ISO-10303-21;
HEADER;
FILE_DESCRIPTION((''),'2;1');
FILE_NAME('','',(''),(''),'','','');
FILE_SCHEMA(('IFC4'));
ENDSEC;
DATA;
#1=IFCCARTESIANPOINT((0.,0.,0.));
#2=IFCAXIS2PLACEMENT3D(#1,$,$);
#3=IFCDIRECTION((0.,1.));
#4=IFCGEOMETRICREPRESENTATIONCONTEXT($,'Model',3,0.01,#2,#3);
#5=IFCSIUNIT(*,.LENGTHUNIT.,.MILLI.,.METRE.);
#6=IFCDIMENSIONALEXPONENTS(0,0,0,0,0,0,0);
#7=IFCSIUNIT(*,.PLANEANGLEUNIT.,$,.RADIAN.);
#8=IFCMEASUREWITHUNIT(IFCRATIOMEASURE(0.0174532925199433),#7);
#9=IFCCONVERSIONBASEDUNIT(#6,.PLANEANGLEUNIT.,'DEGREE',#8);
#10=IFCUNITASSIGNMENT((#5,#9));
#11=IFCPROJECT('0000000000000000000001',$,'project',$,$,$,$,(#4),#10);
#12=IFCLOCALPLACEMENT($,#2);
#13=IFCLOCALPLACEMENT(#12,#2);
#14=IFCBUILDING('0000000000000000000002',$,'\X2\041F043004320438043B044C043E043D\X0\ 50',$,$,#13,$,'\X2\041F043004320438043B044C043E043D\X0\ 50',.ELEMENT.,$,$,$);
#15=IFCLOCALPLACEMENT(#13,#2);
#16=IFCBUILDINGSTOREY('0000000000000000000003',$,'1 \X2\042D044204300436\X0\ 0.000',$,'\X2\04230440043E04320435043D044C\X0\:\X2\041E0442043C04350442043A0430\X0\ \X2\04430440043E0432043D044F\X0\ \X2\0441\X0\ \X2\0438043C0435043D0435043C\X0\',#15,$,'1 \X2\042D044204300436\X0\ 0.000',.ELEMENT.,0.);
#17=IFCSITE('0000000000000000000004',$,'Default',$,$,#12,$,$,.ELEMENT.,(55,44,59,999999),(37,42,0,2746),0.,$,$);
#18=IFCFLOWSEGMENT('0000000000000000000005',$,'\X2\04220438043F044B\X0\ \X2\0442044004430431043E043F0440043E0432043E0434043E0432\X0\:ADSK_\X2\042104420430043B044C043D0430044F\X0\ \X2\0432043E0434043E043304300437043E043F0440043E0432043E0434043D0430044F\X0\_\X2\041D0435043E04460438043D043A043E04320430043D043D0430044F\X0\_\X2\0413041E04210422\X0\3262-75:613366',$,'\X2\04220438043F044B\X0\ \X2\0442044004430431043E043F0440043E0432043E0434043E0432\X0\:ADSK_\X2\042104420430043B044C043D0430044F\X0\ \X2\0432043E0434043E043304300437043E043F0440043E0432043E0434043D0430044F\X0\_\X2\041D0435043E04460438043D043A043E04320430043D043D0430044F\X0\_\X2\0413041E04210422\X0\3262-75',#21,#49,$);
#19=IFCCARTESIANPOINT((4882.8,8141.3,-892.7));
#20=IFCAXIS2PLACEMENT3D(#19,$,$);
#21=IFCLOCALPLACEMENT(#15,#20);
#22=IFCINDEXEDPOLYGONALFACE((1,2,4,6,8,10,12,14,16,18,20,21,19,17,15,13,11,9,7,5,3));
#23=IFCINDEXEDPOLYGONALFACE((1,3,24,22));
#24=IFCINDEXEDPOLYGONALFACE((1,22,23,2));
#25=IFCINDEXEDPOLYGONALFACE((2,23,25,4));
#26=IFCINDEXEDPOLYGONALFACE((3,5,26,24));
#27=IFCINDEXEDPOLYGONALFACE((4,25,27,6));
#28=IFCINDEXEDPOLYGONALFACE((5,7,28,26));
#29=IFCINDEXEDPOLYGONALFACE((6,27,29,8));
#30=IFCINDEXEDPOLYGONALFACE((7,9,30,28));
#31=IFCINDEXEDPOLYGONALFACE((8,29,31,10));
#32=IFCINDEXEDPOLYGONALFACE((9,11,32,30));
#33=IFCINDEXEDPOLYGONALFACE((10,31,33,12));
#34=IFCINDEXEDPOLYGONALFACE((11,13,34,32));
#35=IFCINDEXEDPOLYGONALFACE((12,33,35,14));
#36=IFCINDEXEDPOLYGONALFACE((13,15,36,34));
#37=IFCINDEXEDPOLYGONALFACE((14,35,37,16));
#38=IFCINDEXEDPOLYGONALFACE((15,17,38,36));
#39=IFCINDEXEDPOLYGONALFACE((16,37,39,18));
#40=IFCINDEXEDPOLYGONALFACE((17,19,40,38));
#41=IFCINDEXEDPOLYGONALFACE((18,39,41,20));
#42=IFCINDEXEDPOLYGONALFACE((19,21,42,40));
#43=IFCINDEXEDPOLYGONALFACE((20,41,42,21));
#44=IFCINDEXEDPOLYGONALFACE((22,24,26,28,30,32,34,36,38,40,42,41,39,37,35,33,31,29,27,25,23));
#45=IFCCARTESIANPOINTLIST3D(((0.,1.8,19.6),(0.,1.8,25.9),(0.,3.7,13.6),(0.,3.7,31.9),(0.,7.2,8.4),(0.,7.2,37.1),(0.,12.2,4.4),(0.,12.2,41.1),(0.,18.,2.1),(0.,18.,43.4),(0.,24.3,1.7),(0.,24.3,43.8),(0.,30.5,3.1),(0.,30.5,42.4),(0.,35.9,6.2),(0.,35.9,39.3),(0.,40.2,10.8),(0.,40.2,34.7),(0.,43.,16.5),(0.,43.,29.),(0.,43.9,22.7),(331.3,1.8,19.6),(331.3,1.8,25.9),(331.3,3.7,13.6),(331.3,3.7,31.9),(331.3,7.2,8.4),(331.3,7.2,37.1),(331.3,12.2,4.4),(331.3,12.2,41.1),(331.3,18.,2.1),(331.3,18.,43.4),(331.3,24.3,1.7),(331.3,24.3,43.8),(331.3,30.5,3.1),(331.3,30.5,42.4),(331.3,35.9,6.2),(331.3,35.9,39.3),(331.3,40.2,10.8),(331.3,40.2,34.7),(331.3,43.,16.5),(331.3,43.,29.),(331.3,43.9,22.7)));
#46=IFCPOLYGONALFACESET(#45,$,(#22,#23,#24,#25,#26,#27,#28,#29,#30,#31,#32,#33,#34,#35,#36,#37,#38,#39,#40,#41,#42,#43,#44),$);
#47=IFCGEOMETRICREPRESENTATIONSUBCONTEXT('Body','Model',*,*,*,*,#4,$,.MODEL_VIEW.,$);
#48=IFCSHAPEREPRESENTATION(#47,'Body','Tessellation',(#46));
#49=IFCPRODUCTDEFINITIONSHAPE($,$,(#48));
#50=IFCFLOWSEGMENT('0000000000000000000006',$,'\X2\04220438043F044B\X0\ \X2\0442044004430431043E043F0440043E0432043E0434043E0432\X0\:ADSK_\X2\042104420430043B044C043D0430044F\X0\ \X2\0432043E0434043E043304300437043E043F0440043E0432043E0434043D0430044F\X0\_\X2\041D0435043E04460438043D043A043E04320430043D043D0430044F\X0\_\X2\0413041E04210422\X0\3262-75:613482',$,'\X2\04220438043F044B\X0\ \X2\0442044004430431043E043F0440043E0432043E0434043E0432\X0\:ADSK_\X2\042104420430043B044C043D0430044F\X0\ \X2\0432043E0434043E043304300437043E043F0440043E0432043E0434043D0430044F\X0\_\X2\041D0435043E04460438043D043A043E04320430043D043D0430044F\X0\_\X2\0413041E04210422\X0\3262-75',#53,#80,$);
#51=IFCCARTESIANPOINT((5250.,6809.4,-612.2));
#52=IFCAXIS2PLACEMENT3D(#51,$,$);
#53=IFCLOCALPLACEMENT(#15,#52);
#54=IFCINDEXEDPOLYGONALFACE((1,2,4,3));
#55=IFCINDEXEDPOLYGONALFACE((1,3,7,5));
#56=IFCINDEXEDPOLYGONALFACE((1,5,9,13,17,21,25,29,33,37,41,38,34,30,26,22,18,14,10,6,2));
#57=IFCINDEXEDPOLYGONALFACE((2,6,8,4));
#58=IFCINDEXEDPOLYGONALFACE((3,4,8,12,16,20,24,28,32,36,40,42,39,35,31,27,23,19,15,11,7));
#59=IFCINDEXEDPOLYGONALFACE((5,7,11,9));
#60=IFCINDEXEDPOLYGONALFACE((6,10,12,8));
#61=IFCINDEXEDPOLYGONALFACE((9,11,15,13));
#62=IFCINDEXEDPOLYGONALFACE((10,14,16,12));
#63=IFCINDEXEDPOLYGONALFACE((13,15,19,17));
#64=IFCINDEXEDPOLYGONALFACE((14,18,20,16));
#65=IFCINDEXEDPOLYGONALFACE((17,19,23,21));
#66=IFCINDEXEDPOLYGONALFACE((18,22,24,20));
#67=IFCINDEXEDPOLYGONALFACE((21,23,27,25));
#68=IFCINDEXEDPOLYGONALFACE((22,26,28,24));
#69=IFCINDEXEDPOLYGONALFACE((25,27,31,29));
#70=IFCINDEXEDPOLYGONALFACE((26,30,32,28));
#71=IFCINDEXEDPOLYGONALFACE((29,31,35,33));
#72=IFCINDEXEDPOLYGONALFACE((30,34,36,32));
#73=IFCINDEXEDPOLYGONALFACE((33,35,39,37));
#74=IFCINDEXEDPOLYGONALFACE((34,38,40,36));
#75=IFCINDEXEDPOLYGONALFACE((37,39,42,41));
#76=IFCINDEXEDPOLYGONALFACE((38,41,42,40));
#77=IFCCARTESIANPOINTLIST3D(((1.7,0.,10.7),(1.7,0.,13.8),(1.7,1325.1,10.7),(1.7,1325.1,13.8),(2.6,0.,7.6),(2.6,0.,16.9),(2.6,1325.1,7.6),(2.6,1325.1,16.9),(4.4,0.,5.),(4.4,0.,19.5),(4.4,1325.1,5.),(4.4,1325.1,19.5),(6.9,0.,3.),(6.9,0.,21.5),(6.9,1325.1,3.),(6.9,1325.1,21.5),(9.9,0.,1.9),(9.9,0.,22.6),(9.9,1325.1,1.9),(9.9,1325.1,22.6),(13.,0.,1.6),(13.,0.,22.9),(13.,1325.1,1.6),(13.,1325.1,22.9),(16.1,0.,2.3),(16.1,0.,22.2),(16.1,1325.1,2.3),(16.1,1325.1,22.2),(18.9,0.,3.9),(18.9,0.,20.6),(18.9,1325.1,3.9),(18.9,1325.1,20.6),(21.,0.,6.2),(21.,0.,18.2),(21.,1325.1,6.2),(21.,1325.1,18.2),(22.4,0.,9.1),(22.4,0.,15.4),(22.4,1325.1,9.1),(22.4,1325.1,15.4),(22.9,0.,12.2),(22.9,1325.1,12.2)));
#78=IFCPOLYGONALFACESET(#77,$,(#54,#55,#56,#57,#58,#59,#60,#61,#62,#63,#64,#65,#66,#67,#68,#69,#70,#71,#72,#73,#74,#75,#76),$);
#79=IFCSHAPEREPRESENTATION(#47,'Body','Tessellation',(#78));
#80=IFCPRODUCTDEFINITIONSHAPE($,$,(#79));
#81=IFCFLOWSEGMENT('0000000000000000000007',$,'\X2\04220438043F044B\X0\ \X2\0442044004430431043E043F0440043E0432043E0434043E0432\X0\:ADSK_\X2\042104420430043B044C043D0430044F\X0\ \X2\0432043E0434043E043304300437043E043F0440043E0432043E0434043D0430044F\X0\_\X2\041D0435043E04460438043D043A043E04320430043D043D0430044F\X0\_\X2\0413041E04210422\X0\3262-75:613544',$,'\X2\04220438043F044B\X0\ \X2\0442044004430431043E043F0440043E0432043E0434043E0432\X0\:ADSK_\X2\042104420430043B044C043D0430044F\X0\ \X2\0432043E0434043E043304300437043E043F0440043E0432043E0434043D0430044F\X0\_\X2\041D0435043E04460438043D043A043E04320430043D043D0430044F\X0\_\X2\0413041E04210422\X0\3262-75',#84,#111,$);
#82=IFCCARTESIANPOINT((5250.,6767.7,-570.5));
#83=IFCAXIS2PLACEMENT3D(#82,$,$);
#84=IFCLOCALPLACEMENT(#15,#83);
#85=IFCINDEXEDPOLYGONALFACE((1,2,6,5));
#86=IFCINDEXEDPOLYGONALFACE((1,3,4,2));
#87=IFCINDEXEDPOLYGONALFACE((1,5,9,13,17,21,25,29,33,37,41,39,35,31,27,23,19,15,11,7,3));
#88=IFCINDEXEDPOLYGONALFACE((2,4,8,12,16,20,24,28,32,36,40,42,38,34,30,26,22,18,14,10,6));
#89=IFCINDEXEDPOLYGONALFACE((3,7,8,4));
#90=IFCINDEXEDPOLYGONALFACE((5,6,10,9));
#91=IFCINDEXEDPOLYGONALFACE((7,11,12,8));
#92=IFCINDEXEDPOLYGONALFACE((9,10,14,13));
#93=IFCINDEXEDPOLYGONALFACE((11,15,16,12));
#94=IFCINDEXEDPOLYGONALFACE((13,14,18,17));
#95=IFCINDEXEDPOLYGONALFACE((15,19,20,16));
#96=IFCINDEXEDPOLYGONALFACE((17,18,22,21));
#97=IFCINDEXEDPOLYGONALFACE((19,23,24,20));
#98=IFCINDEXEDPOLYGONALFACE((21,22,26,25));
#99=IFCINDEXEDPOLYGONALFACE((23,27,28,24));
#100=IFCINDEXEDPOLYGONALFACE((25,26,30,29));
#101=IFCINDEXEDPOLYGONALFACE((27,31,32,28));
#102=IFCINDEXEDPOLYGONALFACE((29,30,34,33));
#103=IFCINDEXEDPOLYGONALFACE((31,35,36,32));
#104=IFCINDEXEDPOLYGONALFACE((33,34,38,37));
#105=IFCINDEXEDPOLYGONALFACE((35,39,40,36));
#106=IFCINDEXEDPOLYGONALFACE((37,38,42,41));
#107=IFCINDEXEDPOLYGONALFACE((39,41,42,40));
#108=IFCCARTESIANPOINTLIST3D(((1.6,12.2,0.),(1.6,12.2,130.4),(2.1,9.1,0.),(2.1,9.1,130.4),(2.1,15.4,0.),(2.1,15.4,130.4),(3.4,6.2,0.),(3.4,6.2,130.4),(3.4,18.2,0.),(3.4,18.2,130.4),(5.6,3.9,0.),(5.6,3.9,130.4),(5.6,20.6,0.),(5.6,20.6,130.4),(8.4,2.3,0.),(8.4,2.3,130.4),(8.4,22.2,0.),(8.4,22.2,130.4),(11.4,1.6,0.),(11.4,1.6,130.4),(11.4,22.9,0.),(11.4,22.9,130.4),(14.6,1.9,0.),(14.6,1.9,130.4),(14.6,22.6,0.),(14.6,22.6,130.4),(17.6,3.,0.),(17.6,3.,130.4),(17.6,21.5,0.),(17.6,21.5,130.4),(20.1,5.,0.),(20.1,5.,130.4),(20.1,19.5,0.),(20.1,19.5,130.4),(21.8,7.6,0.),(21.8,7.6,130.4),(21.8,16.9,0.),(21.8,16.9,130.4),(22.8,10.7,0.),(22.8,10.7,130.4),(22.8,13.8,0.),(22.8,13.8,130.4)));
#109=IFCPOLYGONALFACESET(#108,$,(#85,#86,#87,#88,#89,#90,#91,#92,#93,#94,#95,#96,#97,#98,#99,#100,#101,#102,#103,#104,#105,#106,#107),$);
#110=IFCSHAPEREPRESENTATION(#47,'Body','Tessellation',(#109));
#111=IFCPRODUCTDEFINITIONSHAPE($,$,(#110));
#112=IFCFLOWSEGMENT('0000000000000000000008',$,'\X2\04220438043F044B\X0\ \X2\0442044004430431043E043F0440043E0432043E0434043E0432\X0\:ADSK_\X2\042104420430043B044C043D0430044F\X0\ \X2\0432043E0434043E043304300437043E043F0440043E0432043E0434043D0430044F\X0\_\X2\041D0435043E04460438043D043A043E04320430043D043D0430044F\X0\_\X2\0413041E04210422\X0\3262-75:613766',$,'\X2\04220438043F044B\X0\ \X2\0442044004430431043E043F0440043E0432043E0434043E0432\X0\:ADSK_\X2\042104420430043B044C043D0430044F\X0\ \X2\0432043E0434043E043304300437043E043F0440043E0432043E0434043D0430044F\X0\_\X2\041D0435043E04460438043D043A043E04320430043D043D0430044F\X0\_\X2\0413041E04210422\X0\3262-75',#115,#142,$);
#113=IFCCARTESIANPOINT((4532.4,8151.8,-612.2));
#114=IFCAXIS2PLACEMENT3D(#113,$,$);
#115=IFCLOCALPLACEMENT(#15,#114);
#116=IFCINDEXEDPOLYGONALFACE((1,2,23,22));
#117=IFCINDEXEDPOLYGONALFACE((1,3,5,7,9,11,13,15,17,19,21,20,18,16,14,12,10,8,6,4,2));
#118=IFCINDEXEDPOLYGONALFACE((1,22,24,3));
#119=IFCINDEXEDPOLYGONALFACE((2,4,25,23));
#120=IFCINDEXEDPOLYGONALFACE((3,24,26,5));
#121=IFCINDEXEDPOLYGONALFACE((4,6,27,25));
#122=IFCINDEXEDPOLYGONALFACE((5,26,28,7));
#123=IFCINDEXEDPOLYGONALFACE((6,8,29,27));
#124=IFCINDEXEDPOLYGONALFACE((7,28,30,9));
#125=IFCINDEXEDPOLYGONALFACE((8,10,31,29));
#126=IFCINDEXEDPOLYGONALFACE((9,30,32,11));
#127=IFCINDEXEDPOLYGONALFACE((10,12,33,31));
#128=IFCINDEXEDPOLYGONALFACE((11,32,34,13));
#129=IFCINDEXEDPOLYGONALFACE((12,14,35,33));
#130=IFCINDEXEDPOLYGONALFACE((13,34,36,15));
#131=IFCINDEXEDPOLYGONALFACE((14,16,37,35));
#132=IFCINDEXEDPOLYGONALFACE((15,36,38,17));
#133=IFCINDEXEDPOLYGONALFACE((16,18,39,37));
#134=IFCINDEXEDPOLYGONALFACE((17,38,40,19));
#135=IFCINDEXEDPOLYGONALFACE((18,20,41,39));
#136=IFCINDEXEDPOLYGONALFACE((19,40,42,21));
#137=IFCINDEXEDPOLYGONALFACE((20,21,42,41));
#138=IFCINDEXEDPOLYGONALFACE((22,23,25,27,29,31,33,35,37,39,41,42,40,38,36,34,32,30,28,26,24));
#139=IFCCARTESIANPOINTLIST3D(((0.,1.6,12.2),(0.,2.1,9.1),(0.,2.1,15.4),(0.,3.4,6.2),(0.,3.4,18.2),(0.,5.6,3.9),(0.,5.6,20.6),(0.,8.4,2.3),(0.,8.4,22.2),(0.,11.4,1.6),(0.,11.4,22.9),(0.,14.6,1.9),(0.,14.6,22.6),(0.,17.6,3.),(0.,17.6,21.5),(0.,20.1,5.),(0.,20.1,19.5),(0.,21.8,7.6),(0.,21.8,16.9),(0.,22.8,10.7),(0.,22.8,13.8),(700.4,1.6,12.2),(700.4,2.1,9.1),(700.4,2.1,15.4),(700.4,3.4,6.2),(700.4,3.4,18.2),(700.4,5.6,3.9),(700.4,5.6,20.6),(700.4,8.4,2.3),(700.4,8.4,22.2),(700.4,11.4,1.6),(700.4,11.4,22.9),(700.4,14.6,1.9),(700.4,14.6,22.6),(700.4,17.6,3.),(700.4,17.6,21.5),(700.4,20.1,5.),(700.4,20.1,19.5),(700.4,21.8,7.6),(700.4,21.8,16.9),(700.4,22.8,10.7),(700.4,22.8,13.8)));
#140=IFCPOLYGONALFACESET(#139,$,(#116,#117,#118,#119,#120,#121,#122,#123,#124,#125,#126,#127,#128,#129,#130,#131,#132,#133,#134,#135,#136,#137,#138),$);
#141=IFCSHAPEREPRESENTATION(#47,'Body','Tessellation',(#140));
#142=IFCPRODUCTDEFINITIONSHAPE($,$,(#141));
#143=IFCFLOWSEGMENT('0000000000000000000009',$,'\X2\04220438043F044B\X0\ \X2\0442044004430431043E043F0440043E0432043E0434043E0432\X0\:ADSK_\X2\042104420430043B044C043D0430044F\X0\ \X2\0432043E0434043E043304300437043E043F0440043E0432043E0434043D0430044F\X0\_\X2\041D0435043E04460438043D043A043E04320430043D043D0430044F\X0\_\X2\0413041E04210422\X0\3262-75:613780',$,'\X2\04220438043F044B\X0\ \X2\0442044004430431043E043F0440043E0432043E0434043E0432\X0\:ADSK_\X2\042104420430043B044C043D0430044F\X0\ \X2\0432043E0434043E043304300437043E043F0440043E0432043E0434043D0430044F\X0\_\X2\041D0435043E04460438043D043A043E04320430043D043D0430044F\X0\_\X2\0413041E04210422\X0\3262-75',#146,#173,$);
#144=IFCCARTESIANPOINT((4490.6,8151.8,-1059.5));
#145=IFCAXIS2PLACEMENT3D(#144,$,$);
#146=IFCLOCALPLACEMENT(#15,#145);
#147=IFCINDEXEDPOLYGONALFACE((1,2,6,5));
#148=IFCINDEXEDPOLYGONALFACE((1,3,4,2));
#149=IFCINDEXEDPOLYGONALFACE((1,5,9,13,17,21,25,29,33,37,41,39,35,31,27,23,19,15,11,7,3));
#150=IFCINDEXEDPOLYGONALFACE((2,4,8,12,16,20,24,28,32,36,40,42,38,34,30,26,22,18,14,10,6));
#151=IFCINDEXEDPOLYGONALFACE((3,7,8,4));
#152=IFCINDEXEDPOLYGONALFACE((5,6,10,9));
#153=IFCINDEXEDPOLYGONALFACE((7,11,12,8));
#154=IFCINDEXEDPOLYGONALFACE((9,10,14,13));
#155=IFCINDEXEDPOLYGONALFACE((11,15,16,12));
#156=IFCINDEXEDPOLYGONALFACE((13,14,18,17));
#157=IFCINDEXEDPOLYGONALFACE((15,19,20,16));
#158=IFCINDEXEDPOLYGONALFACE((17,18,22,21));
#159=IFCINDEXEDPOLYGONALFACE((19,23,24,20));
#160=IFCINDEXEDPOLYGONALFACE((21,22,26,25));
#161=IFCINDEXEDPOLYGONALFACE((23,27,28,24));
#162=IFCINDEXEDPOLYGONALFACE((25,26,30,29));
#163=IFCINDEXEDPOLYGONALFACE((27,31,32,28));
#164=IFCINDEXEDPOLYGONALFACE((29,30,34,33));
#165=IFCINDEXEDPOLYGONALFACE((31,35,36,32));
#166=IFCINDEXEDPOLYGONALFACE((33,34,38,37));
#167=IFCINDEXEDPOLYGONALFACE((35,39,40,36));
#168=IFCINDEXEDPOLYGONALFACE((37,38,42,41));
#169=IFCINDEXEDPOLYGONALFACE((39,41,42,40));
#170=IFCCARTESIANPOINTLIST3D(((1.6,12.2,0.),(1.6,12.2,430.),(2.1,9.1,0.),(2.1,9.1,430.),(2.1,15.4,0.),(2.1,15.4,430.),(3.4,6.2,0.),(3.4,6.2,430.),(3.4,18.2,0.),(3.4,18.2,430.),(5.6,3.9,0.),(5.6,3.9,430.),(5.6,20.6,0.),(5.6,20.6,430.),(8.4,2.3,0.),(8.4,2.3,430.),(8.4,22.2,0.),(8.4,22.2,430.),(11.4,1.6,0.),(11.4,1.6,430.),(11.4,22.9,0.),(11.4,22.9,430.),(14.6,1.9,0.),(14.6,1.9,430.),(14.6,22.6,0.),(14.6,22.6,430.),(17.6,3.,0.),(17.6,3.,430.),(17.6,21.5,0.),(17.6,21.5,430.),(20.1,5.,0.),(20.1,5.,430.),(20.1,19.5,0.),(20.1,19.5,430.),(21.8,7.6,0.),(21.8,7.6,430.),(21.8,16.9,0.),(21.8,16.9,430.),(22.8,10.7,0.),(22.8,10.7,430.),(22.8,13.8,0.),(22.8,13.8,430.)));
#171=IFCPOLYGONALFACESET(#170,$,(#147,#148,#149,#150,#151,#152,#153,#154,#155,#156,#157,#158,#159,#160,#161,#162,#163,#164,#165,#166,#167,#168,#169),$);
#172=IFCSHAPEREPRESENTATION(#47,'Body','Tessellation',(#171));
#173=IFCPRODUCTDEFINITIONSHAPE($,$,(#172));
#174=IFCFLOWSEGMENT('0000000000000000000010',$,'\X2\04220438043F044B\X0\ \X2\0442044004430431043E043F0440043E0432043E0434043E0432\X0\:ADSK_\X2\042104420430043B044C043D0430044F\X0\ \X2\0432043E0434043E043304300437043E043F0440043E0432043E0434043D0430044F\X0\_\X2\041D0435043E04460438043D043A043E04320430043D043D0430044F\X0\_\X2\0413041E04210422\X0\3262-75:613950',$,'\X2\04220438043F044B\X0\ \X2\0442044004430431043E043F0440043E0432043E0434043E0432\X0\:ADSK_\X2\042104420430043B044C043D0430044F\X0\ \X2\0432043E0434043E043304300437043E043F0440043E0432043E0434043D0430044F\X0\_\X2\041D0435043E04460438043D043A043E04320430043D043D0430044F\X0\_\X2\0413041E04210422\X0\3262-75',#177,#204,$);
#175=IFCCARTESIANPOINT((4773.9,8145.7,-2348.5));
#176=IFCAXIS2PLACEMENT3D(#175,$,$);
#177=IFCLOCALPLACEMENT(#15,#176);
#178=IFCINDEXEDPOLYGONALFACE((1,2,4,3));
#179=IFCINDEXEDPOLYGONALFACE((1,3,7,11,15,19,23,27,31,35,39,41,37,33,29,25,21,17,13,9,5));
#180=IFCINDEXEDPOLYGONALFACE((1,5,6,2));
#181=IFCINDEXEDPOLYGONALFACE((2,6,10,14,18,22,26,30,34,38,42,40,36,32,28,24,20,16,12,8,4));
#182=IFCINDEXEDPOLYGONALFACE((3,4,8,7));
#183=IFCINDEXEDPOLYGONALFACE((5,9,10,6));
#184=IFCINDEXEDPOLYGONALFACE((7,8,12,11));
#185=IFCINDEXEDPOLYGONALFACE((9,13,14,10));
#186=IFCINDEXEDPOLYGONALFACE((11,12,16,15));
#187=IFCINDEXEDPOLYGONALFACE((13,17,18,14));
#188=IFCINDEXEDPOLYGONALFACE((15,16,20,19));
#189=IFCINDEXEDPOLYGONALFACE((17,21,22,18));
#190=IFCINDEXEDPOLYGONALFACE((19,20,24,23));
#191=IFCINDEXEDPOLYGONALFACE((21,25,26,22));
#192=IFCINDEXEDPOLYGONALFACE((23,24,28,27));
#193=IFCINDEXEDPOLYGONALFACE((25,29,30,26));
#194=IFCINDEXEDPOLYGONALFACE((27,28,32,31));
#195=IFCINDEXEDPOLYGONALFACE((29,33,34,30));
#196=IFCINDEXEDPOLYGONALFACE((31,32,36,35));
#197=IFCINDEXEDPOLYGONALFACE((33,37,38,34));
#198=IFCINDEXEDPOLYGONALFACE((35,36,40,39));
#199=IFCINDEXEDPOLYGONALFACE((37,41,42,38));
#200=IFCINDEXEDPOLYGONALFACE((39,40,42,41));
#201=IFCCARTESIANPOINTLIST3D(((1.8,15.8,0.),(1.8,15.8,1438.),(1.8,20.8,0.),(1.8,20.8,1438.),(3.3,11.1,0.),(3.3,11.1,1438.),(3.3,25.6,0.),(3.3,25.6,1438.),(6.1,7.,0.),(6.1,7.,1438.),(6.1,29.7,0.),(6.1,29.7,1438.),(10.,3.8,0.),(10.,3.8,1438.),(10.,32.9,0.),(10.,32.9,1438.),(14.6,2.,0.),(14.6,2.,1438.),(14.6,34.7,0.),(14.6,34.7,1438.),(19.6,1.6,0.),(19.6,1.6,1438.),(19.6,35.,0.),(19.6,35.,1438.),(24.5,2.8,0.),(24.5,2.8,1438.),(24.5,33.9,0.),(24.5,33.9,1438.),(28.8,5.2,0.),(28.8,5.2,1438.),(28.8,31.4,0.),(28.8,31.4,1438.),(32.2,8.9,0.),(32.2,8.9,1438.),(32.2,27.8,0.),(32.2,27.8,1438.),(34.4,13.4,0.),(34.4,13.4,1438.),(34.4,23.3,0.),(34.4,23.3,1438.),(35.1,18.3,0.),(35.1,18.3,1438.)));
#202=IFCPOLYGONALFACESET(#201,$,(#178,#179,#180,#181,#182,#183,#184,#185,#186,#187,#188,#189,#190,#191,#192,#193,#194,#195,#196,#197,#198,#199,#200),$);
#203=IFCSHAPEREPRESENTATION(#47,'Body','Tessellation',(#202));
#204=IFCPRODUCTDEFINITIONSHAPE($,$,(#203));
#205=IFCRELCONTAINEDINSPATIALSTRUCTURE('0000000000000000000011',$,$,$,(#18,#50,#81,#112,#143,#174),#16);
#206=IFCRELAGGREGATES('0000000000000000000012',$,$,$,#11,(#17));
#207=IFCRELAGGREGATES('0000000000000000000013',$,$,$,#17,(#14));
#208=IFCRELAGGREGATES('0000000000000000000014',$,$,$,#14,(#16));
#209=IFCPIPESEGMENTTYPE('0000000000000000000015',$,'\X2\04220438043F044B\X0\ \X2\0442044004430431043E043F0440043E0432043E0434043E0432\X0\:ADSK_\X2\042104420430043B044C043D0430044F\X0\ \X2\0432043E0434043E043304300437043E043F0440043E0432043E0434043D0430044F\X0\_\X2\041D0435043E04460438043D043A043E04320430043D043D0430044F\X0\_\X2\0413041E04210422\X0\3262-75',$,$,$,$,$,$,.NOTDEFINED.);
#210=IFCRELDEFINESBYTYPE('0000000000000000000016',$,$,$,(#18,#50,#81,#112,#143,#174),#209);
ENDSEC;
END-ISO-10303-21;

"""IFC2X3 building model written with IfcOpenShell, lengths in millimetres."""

from ifc_helpers import new_model, entity, si_unit, converted_unit, direction, frame, frame_2d, origin, origin_2d_with_axis, place, context, subcontext, project, spatial, circle, extrude, type_object, element, save


model = new_model("IFC2X3")

# Units and contexts
model_context = context("Model", 3, precision=0.01, world=origin(), true_north=direction((0.0, 1.0)))
body_context = subcontext(model_context, "Body", "Model", "MODEL_VIEW")
ifc_project = project(units=[si_unit("LENGTHUNIT", "METRE", prefix="MILLI"), converted_unit("PLANEANGLEUNIT", "DEGREE", entity("IfcRatioMeasure", 0.0174532925199433), si_unit("PLANEANGLEUNIT", "RADIAN"), dimensions=[0, 0, 0, 0, 0, 0, 0])], contexts=[model_context])

# Site, building, storey
site_placement = place(None, origin())
site = spatial("IfcSite", under=ifc_project, at=site_placement, Name="Default", CompositionType="ELEMENT", RefLatitude=(55, 44, 59, 999999), RefLongitude=(37, 42, 0, 2746), RefElevation=0.0)
building_placement = place(site_placement, origin())
building = spatial("IfcBuilding", under=site, at=building_placement, Name="Павильон 50", LongName="Павильон 50", CompositionType="ELEMENT")
storey_placement = place(building_placement, origin())
storey = spatial("IfcBuildingStorey", under=building, at=storey_placement, Name="1 Этаж 0.000", ObjectType="Уровень:Отметка уровня с именем", LongName="1 Этаж 0.000", CompositionType="ELEMENT", Elevation=0.0)

# Flow segments
pipe_segment_type = type_object("IfcPipeSegmentType", Name="Типы трубопроводов:ADSK_Стальная водогазопроводная_Неоцинкованная_ГОСТ3262-75", PredefinedType="NOTDEFINED")
flow_segment_1_placement = place(storey_placement, frame((4882.8, 8141.3, -892.7)))
element("IfcFlowSegment", 1, at=flow_segment_1_placement, inside=storey, type_object=pipe_segment_type, Name="Типы трубопроводов:ADSK_Стальная водогазопроводная_Неоцинкованная_ГОСТ3262-75:613366", ObjectType="Типы трубопроводов:ADSK_Стальная водогазопроводная_Неоцинкованная_ГОСТ3262-75", context=body_context, shape_type="SweptSolid", body=[
    extrude(circle(Radius=21.1, at=frame_2d((0.0, 0.0), x_axis=(1.0, 0.0))), frame((0.0, 22.7, 22.7), z_axis=(1.0, 0.0, 0.0), x_axis=(0.0, 1.0, 0.0)), (0.0, 0.0, 1.0), 331.3),
])
flow_segment_2_placement = place(storey_placement, frame((5250.0, 6809.4, -612.2)))
element("IfcFlowSegment", 2, at=flow_segment_2_placement, inside=storey, type_object=pipe_segment_type, Name="Типы трубопроводов:ADSK_Стальная водогазопроводная_Неоцинкованная_ГОСТ3262-75:613482", ObjectType="Типы трубопроводов:ADSK_Стальная водогазопроводная_Неоцинкованная_ГОСТ3262-75", context=body_context, shape_type="SweptSolid", body=[
    extrude(circle(Radius=10.7, at=origin_2d_with_axis()), frame((12.2, 0.0, 12.2), z_axis=(0.0, 1.0, 0.0), x_axis=(1.0, 0.0, 0.0)), (0.0, 0.0, 1.0), 1325.1),
])
flow_segment_3_placement = place(storey_placement, frame((5250.0, 6767.7, -570.5)))
element("IfcFlowSegment", 3, at=flow_segment_3_placement, inside=storey, type_object=pipe_segment_type, Name="Типы трубопроводов:ADSK_Стальная водогазопроводная_Неоцинкованная_ГОСТ3262-75:613544", ObjectType="Типы трубопроводов:ADSK_Стальная водогазопроводная_Неоцинкованная_ГОСТ3262-75", context=body_context, shape_type="SweptSolid", body=[
    extrude(circle(Radius=10.7, at=origin_2d_with_axis()), frame((12.2, 12.2, 0.0), z_axis=(0.0, 0.0, 1.0), x_axis=(-1.0, 0.0, 0.0)), (0.0, 0.0, 1.0), 130.4),
])
flow_segment_4_placement = place(storey_placement, frame((4532.4, 8151.8, -612.2)))
element("IfcFlowSegment", 4, at=flow_segment_4_placement, inside=storey, type_object=pipe_segment_type, Name="Типы трубопроводов:ADSK_Стальная водогазопроводная_Неоцинкованная_ГОСТ3262-75:613766", ObjectType="Типы трубопроводов:ADSK_Стальная водогазопроводная_Неоцинкованная_ГОСТ3262-75", context=body_context, shape_type="SweptSolid", body=[
    extrude(circle(Radius=10.7, at=origin_2d_with_axis()), frame((0.0, 12.2, 12.2), z_axis=(1.0, 0.0, 0.0), x_axis=(0.0, -1.0, 0.0)), (0.0, 0.0, 1.0), 700.4),
])
flow_segment_5_placement = place(storey_placement, frame((4490.6, 8151.8, -1059.5)))
element("IfcFlowSegment", 5, at=flow_segment_5_placement, inside=storey, type_object=pipe_segment_type, Name="Типы трубопроводов:ADSK_Стальная водогазопроводная_Неоцинкованная_ГОСТ3262-75:613780", ObjectType="Типы трубопроводов:ADSK_Стальная водогазопроводная_Неоцинкованная_ГОСТ3262-75", context=body_context, shape_type="SweptSolid", body=[
    extrude(circle(Radius=10.7, at=origin_2d_with_axis()), frame((12.2, 12.2, 0.0), z_axis=(0.0, 0.0, 1.0), x_axis=(-1.0, 0.0, 0.0)), (0.0, 0.0, 1.0), 430.0),
])
flow_segment_6_placement = place(storey_placement, frame((4773.9, 8145.7, -2348.5)))
element("IfcFlowSegment", 6, at=flow_segment_6_placement, inside=storey, type_object=pipe_segment_type, Name="Типы трубопроводов:ADSK_Стальная водогазопроводная_Неоцинкованная_ГОСТ3262-75:613950", ObjectType="Типы трубопроводов:ADSK_Стальная водогазопроводная_Неоцинкованная_ГОСТ3262-75", context=body_context, shape_type="SweptSolid", body=[
    extrude(circle(Radius=16.8, at=origin_2d_with_axis()), frame((18.3, 18.3, 0.0)), (0.0, 0.0, 1.0), 1438.0),
])

save(model, "model.ifc")
